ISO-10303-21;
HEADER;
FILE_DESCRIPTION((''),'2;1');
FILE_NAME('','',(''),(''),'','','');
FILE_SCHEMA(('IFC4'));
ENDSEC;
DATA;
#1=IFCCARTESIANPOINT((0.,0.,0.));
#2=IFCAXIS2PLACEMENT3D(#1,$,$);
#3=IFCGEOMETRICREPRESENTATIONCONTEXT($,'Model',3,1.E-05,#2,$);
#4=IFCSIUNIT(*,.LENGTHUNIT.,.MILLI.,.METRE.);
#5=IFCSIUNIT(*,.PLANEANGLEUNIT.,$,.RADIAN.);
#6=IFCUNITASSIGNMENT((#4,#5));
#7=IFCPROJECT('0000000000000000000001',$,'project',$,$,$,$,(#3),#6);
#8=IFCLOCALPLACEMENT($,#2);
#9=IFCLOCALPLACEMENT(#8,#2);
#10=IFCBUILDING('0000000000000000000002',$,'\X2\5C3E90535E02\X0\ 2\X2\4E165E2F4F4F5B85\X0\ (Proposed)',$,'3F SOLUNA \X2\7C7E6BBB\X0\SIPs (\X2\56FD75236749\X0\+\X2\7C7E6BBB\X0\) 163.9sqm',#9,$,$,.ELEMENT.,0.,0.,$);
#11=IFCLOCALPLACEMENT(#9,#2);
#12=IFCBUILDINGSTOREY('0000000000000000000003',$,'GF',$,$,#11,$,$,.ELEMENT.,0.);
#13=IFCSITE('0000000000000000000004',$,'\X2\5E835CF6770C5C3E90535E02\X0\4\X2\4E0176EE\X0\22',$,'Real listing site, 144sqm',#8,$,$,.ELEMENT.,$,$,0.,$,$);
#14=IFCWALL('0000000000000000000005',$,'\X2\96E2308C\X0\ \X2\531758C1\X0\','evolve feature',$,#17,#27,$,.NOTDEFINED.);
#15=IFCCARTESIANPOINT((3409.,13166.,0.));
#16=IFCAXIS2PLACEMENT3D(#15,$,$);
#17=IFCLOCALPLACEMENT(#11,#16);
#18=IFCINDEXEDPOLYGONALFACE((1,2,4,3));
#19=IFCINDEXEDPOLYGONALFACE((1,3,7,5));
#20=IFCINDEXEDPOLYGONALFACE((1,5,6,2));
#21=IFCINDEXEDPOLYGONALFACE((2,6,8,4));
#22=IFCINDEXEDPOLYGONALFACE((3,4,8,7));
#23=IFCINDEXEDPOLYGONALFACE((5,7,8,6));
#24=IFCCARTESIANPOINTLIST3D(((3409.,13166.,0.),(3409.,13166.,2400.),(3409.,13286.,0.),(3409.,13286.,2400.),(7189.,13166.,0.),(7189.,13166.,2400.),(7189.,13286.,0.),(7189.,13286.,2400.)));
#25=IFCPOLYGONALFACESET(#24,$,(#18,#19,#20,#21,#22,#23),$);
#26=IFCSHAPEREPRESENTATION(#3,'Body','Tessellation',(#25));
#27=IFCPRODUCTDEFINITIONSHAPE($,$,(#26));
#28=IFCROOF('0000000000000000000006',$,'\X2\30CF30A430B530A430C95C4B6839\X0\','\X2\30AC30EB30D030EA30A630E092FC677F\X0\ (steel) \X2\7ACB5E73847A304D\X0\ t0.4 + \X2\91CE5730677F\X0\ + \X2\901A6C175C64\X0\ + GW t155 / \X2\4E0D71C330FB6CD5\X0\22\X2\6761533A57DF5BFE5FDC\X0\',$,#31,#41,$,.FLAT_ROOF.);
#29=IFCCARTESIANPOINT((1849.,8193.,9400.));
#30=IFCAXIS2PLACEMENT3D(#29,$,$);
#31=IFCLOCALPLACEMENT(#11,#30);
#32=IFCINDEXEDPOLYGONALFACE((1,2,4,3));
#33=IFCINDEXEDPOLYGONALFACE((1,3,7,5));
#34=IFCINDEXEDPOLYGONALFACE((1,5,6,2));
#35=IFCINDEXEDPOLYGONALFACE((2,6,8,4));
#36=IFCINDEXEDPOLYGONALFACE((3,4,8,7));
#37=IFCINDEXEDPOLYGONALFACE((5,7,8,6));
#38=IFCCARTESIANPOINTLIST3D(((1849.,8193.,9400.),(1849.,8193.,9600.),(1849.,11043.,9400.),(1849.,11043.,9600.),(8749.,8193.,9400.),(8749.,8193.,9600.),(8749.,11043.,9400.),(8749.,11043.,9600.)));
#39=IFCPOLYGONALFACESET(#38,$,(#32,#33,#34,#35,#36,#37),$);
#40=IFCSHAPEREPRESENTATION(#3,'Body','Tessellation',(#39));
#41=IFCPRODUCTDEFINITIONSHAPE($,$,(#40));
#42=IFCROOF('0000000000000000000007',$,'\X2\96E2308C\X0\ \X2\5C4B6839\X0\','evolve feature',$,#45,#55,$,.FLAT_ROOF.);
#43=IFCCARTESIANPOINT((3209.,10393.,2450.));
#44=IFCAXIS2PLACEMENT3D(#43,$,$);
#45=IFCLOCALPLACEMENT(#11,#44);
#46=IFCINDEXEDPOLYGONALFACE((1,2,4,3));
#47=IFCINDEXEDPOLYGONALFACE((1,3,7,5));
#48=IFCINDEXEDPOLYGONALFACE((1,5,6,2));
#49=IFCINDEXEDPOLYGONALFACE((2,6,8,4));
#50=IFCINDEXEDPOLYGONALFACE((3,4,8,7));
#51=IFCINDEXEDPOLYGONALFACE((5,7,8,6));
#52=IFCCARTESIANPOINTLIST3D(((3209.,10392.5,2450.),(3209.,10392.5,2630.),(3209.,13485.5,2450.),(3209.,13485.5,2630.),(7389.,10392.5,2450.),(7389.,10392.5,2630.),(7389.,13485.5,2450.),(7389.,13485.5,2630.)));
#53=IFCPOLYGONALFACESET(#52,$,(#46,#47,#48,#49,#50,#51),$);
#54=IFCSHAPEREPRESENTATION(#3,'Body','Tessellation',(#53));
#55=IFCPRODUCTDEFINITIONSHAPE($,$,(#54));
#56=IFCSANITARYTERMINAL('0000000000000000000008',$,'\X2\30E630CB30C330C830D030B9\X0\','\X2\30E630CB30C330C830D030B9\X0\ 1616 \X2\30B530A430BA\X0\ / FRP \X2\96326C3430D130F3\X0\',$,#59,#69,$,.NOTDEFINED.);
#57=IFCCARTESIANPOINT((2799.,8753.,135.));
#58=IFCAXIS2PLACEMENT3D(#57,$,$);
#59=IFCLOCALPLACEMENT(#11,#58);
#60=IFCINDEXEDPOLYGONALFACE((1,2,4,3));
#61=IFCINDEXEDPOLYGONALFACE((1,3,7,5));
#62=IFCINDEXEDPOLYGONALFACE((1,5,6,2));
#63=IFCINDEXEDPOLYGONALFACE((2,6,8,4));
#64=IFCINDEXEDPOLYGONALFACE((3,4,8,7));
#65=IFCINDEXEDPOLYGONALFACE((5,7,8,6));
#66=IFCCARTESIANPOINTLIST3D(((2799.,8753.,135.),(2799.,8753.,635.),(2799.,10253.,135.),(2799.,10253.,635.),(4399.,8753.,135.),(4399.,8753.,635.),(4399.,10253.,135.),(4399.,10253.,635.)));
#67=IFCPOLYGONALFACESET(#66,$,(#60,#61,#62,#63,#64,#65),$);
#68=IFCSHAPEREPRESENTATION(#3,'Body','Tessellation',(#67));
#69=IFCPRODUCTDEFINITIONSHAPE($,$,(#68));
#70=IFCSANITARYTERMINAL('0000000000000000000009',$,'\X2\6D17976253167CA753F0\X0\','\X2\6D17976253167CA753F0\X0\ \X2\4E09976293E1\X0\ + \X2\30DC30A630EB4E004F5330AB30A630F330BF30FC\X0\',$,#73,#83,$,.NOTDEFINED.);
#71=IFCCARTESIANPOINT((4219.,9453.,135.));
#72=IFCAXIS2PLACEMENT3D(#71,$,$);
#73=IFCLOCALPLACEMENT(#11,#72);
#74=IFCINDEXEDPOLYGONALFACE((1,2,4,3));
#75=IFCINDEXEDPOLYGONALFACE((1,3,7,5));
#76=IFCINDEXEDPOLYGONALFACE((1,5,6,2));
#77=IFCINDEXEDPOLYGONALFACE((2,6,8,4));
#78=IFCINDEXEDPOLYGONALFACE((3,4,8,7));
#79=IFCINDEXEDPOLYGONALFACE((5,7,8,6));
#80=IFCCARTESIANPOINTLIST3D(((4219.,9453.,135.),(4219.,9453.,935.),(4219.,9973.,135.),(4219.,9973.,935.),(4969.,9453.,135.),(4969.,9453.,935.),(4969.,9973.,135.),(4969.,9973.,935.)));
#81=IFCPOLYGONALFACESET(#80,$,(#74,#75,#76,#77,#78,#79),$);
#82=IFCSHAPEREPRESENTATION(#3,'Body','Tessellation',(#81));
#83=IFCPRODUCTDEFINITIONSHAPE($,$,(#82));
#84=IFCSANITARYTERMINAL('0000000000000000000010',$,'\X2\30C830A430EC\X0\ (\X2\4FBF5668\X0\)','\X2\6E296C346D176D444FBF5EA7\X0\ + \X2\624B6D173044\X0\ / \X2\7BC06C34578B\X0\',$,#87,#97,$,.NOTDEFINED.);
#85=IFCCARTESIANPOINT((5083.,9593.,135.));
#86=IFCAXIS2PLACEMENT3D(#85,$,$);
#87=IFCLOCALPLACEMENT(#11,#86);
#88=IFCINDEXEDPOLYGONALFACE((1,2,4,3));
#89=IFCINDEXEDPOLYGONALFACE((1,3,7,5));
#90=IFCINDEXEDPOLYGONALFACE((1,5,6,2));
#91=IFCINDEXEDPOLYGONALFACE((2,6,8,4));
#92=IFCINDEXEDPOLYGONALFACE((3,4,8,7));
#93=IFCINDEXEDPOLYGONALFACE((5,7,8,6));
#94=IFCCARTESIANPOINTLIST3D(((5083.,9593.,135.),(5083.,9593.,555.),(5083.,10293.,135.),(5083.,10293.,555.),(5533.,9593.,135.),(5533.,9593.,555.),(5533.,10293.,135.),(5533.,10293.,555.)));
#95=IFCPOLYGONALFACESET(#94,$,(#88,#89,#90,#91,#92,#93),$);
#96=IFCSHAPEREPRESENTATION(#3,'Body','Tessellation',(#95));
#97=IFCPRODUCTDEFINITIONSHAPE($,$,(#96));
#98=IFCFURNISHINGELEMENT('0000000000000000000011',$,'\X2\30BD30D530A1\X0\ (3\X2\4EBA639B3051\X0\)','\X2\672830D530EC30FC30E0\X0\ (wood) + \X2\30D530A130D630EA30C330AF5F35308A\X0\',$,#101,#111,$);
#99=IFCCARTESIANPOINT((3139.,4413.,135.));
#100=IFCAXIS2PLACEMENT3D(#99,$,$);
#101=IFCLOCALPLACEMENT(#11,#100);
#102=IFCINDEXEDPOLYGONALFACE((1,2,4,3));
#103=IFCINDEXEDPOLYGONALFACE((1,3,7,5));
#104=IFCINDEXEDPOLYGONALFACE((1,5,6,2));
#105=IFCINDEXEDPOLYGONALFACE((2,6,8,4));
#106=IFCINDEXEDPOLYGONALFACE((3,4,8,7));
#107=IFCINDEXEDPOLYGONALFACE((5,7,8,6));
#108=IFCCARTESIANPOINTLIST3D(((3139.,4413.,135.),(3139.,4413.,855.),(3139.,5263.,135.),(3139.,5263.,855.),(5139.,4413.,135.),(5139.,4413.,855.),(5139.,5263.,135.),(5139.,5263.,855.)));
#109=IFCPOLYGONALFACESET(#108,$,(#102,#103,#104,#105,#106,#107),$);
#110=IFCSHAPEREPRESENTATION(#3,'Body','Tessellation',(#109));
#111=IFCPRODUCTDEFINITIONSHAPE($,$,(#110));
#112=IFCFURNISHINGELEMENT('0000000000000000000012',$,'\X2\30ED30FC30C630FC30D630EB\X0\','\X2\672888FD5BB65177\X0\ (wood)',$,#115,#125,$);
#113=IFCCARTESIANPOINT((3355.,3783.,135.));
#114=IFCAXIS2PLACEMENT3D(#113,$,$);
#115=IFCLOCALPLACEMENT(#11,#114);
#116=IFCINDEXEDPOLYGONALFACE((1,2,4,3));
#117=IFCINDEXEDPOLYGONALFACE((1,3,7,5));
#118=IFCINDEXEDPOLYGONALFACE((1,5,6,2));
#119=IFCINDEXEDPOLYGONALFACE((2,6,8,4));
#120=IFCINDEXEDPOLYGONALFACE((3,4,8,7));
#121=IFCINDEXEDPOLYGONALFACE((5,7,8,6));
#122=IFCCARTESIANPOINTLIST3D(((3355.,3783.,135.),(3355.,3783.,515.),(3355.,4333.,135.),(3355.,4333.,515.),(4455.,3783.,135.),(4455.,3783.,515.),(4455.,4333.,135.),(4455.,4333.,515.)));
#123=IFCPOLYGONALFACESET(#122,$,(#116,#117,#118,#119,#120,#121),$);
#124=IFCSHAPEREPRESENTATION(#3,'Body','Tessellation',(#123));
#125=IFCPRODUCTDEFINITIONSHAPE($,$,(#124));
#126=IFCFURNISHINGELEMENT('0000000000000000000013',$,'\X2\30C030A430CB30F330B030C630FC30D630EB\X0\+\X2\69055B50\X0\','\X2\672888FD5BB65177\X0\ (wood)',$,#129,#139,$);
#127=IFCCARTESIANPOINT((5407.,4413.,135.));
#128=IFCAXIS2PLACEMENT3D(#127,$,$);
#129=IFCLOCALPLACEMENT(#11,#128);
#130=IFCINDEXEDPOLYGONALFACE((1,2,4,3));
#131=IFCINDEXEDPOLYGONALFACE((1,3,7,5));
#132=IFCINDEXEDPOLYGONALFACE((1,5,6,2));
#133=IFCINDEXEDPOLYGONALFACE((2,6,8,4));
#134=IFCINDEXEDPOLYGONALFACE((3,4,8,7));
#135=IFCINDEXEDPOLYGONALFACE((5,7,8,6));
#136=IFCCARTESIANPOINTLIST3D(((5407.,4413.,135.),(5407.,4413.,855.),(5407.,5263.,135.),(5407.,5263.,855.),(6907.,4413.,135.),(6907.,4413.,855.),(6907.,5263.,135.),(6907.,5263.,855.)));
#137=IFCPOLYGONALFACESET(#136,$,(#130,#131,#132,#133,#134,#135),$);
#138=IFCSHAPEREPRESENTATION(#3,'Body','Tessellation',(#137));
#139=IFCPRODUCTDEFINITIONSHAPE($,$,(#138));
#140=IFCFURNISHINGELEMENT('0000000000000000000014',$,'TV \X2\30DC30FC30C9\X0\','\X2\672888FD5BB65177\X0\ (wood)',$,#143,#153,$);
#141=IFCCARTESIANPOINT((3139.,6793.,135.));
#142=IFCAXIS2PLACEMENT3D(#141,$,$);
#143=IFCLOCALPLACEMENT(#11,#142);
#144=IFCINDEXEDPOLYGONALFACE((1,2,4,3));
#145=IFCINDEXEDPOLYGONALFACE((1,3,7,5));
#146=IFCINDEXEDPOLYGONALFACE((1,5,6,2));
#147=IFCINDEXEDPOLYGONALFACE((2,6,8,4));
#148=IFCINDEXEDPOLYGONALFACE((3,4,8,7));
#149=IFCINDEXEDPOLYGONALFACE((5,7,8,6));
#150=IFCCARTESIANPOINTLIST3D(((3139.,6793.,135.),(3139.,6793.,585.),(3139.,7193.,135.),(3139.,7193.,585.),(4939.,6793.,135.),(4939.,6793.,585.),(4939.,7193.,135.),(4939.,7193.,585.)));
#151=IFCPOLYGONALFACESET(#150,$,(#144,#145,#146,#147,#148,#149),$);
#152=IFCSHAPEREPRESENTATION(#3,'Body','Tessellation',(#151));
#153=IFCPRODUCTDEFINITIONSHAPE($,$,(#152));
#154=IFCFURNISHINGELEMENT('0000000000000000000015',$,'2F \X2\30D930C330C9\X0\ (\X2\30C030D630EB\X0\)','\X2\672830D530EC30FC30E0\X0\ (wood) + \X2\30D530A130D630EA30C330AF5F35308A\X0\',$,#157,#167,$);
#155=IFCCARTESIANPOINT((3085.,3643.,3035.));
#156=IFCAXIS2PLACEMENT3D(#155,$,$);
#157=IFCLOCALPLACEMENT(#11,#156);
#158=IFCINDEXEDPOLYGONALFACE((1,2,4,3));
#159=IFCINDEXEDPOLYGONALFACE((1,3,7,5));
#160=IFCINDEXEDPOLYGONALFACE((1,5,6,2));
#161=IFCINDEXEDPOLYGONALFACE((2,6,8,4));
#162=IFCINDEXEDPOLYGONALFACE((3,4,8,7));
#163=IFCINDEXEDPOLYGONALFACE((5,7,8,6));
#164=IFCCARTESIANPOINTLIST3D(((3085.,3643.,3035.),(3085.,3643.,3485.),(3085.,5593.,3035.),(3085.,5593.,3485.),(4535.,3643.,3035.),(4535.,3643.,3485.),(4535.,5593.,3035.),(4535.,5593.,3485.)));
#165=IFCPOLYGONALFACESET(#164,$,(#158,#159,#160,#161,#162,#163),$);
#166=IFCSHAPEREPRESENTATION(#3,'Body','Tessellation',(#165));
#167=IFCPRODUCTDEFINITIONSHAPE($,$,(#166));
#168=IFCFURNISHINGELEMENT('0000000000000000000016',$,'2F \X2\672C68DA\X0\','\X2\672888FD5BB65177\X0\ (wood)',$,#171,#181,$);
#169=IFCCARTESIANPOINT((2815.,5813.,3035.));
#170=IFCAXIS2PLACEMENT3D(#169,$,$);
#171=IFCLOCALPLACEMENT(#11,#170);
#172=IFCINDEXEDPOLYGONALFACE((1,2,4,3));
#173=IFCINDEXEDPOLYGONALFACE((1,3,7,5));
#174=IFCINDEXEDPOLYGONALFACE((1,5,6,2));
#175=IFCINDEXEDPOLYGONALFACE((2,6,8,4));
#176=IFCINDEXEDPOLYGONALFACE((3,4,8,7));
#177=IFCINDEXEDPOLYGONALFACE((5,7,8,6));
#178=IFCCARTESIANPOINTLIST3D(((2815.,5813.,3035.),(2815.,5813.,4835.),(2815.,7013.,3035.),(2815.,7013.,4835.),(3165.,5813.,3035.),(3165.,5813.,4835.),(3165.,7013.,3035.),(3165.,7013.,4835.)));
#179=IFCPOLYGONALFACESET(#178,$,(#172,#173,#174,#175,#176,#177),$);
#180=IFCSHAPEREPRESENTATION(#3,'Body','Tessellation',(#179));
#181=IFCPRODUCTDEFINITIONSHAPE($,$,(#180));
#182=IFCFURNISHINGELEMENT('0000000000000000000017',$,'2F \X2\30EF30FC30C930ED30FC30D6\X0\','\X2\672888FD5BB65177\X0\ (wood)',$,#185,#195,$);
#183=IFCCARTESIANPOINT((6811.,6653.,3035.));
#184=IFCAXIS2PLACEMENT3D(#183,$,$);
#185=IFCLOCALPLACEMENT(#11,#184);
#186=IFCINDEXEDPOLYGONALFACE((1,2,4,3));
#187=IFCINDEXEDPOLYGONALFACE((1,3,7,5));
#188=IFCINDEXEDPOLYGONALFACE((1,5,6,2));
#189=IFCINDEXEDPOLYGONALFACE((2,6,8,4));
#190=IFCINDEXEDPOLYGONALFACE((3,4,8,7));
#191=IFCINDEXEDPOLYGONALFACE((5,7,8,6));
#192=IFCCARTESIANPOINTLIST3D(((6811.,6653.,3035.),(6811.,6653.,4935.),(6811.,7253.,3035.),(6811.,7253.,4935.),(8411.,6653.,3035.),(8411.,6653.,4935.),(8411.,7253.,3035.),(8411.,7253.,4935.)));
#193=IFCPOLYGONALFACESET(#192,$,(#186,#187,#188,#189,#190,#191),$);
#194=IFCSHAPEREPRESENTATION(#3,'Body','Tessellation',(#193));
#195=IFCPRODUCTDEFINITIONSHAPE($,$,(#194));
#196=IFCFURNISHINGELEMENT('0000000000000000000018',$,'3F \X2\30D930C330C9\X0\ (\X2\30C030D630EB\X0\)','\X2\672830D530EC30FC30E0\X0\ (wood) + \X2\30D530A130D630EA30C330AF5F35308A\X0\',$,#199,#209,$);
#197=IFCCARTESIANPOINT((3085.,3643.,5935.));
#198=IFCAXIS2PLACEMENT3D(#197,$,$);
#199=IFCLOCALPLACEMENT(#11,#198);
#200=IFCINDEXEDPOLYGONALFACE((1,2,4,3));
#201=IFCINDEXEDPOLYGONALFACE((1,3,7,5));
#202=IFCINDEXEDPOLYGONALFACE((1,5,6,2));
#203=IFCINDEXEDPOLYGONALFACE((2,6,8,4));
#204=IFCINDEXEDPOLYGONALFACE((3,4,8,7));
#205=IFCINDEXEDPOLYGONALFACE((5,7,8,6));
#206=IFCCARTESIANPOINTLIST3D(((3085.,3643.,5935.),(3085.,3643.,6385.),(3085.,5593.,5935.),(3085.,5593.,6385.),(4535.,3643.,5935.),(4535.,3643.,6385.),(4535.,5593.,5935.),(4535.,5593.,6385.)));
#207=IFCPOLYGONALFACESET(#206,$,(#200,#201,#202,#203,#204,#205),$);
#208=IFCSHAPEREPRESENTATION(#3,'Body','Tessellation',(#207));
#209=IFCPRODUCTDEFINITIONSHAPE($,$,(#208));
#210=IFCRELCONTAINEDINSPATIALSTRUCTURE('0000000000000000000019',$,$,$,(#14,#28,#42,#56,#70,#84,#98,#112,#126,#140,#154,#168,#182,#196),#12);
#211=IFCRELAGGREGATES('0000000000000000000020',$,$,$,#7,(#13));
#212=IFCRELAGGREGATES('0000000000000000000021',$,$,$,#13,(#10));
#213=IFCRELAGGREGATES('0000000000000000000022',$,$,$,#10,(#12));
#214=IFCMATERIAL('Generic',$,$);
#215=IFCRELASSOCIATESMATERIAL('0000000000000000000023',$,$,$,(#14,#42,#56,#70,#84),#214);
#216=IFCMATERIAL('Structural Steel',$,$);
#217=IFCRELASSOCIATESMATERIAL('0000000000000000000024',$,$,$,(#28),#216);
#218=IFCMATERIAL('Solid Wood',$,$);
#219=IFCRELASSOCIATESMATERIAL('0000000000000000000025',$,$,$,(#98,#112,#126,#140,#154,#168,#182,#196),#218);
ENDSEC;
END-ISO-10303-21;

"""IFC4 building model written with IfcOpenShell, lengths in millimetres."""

from ifc_helpers import new_model, si_unit, frame, frame_2d, origin, place, context, project, spatial, rectangle, extrude, material, element, save


model = new_model("IFC4")

# Units and contexts
model_context = context("Model", 3, precision=1e-05, world=origin())
ifc_project = project(units=[si_unit("LENGTHUNIT", "METRE", prefix="MILLI"), si_unit("PLANEANGLEUNIT", "RADIAN")], contexts=[model_context])

# Site, building, storey
site_placement = place(None, origin())
site = spatial("IfcSite", under=ifc_project, at=site_placement, Name="広島県尾道市4丁目22", ObjectType="Real listing site, 144sqm", CompositionType="ELEMENT", RefElevation=0.0)
building_placement = place(site_placement, origin())
building = spatial("IfcBuilding", under=site, at=building_placement, Name="尾道市 2世帯住宅 (Proposed)", ObjectType="3F SOLUNA 籾殻SIPs (国産杉+籾殻) 163.9sqm", CompositionType="ELEMENT", ElevationOfRefHeight=0.0, ElevationOfTerrain=0.0)
storey_placement = place(building_placement, origin())
storey = spatial("IfcBuildingStorey", under=building, at=storey_placement, Name="GF", CompositionType="ELEMENT", Elevation=0.0)

# Shared definitions
ifc_material_1 = material(Name="Generic")

# Shared definitions
ifc_material_2 = material(Name="Solid Wood")

# Wall
wall_1_placement = place(storey_placement, frame((3409.0, 13166.0, 0.0)))
element("IfcWall", 1, at=wall_1_placement, inside=storey, material=ifc_material_1, Name="離れ 北壁", Description="evolve feature", PredefinedType="NOTDEFINED", context=model_context, shape_type="SweptSolid", body=[
    extrude(rectangle(XDim=3780.0, YDim=120.0, at=frame_2d((1890.0, 60.0))), frame((3409.0, 13166.0, 0.0)), (0.0, 0.0, 1.0), 2400.0),
])

# Roofs
ifc_material_3 = material(Name="Structural Steel")
roof_1_placement = place(storey_placement, frame((1849.0, 8193.0, 9400.0)))
element("IfcRoof", 2, at=roof_1_placement, inside=storey, material=ifc_material_3, Name="ハイサイド屋根", Description="ガルバリウム鋼板 (steel) 立平葺き t0.4 + 野地板 + 通気層 + GW t155 / 不燃・法22条区域対応", PredefinedType="FLAT_ROOF", context=model_context, shape_type="SweptSolid", body=[
    extrude(rectangle(XDim=6900.0, YDim=2850.0, at=frame_2d((3450.0, 1425.0))), frame((1849.0, 8193.0, 9400.0)), (0.0, 0.0, 1.0), 200.0),
])
roof_2_placement = place(storey_placement, frame((3209.0, 10393.0, 2450.0)))
element("IfcRoof", 3, at=roof_2_placement, inside=storey, material=ifc_material_1, Name="離れ 屋根", Description="evolve feature", PredefinedType="FLAT_ROOF", context=model_context, shape_type="SweptSolid", body=[
    extrude(rectangle(XDim=4180.0, YDim=3093.0, at=frame_2d((2090.0, 1546.0))), frame((3209.0, 10393.0, 2450.0)), (0.0, 0.0, 1.0), 180.0),
])

# Sanitary terminals
sanitary_terminal_1_placement = place(storey_placement, frame((2799.0, 8753.0, 135.0)))
element("IfcSanitaryTerminal", 4, at=sanitary_terminal_1_placement, inside=storey, material=ifc_material_1, Name="ユニットバス", Description="ユニットバス 1616 サイズ / FRP 防水パン", PredefinedType="NOTDEFINED", context=model_context, shape_type="SweptSolid", body=[
    extrude(rectangle(XDim=1600.0, YDim=1500.0, at=frame_2d((800.0, 750.0))), frame((2799.0, 8753.0, 135.0)), (0.0, 0.0, 1.0), 500.0),
])
sanitary_terminal_2_placement = place(storey_placement, frame((4219.0, 9453.0, 135.0)))
element("IfcSanitaryTerminal", 5, at=sanitary_terminal_2_placement, inside=storey, material=ifc_material_1, Name="洗面化粧台", Description="洗面化粧台 三面鏡 + ボウル一体カウンター", PredefinedType="NOTDEFINED", context=model_context, shape_type="SweptSolid", body=[
    extrude(rectangle(XDim=750.0, YDim=520.0, at=frame_2d((375.0, 260.0))), frame((4219.0, 9453.0, 135.0)), (0.0, 0.0, 1.0), 800.0),
])
sanitary_terminal_3_placement = place(storey_placement, frame((5083.0, 9593.0, 135.0)))
element("IfcSanitaryTerminal", 6, at=sanitary_terminal_3_placement, inside=storey, material=ifc_material_1, Name="トイレ (便器)", Description="温水洗浄便座 + 手洗い / 節水型", PredefinedType="NOTDEFINED", context=model_context, shape_type="SweptSolid", body=[
    extrude(rectangle(XDim=450.0, YDim=700.0, at=frame_2d((225.0, 350.0))), frame((5083.0, 9593.0, 135.0)), (0.0, 0.0, 1.0), 420.0),
])

# Furnishing elements
furnishing_1_placement = place(storey_placement, frame((3139.0, 4413.0, 135.0)))
element("IfcFurnishingElement", 7, at=furnishing_1_placement, inside=storey, material=ifc_material_2, Name="ソファ (3人掛け)", Description="木フレーム (wood) + ファブリック張り", context=model_context, shape_type="SweptSolid", body=[
    extrude(rectangle(XDim=2000.0, YDim=850.0, at=frame_2d((1000.0, 425.0))), frame((3139.0, 4413.0, 135.0)), (0.0, 0.0, 1.0), 720.0),
])
furnishing_2_placement = place(storey_placement, frame((3355.0, 3783.0, 135.0)))
element("IfcFurnishingElement", 8, at=furnishing_2_placement, inside=storey, material=ifc_material_2, Name="ローテーブル", Description="木製家具 (wood)", context=model_context, shape_type="SweptSolid", body=[
    extrude(rectangle(XDim=1100.0, YDim=550.0, at=frame_2d((550.0, 275.0))), frame((3355.0, 3783.0, 135.0)), (0.0, 0.0, 1.0), 380.0),
])
furnishing_3_placement = place(storey_placement, frame((5407.0, 4413.0, 135.0)))
element("IfcFurnishingElement", 9, at=furnishing_3_placement, inside=storey, material=ifc_material_2, Name="ダイニングテーブル+椅子", Description="木製家具 (wood)", context=model_context, shape_type="SweptSolid", body=[
    extrude(rectangle(XDim=1500.0, YDim=850.0, at=frame_2d((750.0, 425.0))), frame((5407.0, 4413.0, 135.0)), (0.0, 0.0, 1.0), 720.0),
])
furnishing_4_placement = place(storey_placement, frame((3139.0, 6793.0, 135.0)))
element("IfcFurnishingElement", 10, at=furnishing_4_placement, inside=storey, material=ifc_material_2, Name="TV ボード", Description="木製家具 (wood)", context=model_context, shape_type="SweptSolid", body=[
    extrude(rectangle(XDim=1800.0, YDim=400.0, at=frame_2d((900.0, 200.0))), frame((3139.0, 6793.0, 135.0)), (0.0, 0.0, 1.0), 450.0),
])
furnishing_5_placement = place(storey_placement, frame((3085.0, 3643.0, 3035.0)))
element("IfcFurnishingElement", 11, at=furnishing_5_placement, inside=storey, material=ifc_material_2, Name="2F ベッド (ダブル)", Description="木フレーム (wood) + ファブリック張り", context=model_context, shape_type="SweptSolid", body=[
    extrude(rectangle(XDim=1450.0, YDim=1950.0, at=frame_2d((725.0, 975.0))), frame((3085.0, 3643.0, 3035.0)), (0.0, 0.0, 1.0), 450.0),
])
furnishing_6_placement = place(storey_placement, frame((2815.0, 5813.0, 3035.0)))
element("IfcFurnishingElement", 12, at=furnishing_6_placement, inside=storey, material=ifc_material_2, Name="2F 本棚", Description="木製家具 (wood)", context=model_context, shape_type="SweptSolid", body=[
    extrude(rectangle(XDim=350.0, YDim=1200.0, at=frame_2d((175.0, 600.0))), frame((2815.0, 5813.0, 3035.0)), (0.0, 0.0, 1.0), 1800.0),
])
furnishing_7_placement = place(storey_placement, frame((6811.0, 6653.0, 3035.0)))
element("IfcFurnishingElement", 13, at=furnishing_7_placement, inside=storey, material=ifc_material_2, Name="2F ワードローブ", Description="木製家具 (wood)", context=model_context, shape_type="SweptSolid", body=[
    extrude(rectangle(XDim=1600.0, YDim=600.0, at=frame_2d((800.0, 300.0))), frame((6811.0, 6653.0, 3035.0)), (0.0, 0.0, 1.0), 1900.0),
])
furnishing_8_placement = place(storey_placement, frame((3085.0, 3643.0, 5935.0)))
element("IfcFurnishingElement", 14, at=furnishing_8_placement, inside=storey, material=ifc_material_2, Name="3F ベッド (ダブル)", Description="木フレーム (wood) + ファブリック張り", context=model_context, shape_type="SweptSolid", body=[
    extrude(rectangle(XDim=1450.0, YDim=1950.0, at=frame_2d((725.0, 975.0))), frame((3085.0, 3643.0, 5935.0)), (0.0, 0.0, 1.0), 450.0),
])

save(model, "model.ifc")
